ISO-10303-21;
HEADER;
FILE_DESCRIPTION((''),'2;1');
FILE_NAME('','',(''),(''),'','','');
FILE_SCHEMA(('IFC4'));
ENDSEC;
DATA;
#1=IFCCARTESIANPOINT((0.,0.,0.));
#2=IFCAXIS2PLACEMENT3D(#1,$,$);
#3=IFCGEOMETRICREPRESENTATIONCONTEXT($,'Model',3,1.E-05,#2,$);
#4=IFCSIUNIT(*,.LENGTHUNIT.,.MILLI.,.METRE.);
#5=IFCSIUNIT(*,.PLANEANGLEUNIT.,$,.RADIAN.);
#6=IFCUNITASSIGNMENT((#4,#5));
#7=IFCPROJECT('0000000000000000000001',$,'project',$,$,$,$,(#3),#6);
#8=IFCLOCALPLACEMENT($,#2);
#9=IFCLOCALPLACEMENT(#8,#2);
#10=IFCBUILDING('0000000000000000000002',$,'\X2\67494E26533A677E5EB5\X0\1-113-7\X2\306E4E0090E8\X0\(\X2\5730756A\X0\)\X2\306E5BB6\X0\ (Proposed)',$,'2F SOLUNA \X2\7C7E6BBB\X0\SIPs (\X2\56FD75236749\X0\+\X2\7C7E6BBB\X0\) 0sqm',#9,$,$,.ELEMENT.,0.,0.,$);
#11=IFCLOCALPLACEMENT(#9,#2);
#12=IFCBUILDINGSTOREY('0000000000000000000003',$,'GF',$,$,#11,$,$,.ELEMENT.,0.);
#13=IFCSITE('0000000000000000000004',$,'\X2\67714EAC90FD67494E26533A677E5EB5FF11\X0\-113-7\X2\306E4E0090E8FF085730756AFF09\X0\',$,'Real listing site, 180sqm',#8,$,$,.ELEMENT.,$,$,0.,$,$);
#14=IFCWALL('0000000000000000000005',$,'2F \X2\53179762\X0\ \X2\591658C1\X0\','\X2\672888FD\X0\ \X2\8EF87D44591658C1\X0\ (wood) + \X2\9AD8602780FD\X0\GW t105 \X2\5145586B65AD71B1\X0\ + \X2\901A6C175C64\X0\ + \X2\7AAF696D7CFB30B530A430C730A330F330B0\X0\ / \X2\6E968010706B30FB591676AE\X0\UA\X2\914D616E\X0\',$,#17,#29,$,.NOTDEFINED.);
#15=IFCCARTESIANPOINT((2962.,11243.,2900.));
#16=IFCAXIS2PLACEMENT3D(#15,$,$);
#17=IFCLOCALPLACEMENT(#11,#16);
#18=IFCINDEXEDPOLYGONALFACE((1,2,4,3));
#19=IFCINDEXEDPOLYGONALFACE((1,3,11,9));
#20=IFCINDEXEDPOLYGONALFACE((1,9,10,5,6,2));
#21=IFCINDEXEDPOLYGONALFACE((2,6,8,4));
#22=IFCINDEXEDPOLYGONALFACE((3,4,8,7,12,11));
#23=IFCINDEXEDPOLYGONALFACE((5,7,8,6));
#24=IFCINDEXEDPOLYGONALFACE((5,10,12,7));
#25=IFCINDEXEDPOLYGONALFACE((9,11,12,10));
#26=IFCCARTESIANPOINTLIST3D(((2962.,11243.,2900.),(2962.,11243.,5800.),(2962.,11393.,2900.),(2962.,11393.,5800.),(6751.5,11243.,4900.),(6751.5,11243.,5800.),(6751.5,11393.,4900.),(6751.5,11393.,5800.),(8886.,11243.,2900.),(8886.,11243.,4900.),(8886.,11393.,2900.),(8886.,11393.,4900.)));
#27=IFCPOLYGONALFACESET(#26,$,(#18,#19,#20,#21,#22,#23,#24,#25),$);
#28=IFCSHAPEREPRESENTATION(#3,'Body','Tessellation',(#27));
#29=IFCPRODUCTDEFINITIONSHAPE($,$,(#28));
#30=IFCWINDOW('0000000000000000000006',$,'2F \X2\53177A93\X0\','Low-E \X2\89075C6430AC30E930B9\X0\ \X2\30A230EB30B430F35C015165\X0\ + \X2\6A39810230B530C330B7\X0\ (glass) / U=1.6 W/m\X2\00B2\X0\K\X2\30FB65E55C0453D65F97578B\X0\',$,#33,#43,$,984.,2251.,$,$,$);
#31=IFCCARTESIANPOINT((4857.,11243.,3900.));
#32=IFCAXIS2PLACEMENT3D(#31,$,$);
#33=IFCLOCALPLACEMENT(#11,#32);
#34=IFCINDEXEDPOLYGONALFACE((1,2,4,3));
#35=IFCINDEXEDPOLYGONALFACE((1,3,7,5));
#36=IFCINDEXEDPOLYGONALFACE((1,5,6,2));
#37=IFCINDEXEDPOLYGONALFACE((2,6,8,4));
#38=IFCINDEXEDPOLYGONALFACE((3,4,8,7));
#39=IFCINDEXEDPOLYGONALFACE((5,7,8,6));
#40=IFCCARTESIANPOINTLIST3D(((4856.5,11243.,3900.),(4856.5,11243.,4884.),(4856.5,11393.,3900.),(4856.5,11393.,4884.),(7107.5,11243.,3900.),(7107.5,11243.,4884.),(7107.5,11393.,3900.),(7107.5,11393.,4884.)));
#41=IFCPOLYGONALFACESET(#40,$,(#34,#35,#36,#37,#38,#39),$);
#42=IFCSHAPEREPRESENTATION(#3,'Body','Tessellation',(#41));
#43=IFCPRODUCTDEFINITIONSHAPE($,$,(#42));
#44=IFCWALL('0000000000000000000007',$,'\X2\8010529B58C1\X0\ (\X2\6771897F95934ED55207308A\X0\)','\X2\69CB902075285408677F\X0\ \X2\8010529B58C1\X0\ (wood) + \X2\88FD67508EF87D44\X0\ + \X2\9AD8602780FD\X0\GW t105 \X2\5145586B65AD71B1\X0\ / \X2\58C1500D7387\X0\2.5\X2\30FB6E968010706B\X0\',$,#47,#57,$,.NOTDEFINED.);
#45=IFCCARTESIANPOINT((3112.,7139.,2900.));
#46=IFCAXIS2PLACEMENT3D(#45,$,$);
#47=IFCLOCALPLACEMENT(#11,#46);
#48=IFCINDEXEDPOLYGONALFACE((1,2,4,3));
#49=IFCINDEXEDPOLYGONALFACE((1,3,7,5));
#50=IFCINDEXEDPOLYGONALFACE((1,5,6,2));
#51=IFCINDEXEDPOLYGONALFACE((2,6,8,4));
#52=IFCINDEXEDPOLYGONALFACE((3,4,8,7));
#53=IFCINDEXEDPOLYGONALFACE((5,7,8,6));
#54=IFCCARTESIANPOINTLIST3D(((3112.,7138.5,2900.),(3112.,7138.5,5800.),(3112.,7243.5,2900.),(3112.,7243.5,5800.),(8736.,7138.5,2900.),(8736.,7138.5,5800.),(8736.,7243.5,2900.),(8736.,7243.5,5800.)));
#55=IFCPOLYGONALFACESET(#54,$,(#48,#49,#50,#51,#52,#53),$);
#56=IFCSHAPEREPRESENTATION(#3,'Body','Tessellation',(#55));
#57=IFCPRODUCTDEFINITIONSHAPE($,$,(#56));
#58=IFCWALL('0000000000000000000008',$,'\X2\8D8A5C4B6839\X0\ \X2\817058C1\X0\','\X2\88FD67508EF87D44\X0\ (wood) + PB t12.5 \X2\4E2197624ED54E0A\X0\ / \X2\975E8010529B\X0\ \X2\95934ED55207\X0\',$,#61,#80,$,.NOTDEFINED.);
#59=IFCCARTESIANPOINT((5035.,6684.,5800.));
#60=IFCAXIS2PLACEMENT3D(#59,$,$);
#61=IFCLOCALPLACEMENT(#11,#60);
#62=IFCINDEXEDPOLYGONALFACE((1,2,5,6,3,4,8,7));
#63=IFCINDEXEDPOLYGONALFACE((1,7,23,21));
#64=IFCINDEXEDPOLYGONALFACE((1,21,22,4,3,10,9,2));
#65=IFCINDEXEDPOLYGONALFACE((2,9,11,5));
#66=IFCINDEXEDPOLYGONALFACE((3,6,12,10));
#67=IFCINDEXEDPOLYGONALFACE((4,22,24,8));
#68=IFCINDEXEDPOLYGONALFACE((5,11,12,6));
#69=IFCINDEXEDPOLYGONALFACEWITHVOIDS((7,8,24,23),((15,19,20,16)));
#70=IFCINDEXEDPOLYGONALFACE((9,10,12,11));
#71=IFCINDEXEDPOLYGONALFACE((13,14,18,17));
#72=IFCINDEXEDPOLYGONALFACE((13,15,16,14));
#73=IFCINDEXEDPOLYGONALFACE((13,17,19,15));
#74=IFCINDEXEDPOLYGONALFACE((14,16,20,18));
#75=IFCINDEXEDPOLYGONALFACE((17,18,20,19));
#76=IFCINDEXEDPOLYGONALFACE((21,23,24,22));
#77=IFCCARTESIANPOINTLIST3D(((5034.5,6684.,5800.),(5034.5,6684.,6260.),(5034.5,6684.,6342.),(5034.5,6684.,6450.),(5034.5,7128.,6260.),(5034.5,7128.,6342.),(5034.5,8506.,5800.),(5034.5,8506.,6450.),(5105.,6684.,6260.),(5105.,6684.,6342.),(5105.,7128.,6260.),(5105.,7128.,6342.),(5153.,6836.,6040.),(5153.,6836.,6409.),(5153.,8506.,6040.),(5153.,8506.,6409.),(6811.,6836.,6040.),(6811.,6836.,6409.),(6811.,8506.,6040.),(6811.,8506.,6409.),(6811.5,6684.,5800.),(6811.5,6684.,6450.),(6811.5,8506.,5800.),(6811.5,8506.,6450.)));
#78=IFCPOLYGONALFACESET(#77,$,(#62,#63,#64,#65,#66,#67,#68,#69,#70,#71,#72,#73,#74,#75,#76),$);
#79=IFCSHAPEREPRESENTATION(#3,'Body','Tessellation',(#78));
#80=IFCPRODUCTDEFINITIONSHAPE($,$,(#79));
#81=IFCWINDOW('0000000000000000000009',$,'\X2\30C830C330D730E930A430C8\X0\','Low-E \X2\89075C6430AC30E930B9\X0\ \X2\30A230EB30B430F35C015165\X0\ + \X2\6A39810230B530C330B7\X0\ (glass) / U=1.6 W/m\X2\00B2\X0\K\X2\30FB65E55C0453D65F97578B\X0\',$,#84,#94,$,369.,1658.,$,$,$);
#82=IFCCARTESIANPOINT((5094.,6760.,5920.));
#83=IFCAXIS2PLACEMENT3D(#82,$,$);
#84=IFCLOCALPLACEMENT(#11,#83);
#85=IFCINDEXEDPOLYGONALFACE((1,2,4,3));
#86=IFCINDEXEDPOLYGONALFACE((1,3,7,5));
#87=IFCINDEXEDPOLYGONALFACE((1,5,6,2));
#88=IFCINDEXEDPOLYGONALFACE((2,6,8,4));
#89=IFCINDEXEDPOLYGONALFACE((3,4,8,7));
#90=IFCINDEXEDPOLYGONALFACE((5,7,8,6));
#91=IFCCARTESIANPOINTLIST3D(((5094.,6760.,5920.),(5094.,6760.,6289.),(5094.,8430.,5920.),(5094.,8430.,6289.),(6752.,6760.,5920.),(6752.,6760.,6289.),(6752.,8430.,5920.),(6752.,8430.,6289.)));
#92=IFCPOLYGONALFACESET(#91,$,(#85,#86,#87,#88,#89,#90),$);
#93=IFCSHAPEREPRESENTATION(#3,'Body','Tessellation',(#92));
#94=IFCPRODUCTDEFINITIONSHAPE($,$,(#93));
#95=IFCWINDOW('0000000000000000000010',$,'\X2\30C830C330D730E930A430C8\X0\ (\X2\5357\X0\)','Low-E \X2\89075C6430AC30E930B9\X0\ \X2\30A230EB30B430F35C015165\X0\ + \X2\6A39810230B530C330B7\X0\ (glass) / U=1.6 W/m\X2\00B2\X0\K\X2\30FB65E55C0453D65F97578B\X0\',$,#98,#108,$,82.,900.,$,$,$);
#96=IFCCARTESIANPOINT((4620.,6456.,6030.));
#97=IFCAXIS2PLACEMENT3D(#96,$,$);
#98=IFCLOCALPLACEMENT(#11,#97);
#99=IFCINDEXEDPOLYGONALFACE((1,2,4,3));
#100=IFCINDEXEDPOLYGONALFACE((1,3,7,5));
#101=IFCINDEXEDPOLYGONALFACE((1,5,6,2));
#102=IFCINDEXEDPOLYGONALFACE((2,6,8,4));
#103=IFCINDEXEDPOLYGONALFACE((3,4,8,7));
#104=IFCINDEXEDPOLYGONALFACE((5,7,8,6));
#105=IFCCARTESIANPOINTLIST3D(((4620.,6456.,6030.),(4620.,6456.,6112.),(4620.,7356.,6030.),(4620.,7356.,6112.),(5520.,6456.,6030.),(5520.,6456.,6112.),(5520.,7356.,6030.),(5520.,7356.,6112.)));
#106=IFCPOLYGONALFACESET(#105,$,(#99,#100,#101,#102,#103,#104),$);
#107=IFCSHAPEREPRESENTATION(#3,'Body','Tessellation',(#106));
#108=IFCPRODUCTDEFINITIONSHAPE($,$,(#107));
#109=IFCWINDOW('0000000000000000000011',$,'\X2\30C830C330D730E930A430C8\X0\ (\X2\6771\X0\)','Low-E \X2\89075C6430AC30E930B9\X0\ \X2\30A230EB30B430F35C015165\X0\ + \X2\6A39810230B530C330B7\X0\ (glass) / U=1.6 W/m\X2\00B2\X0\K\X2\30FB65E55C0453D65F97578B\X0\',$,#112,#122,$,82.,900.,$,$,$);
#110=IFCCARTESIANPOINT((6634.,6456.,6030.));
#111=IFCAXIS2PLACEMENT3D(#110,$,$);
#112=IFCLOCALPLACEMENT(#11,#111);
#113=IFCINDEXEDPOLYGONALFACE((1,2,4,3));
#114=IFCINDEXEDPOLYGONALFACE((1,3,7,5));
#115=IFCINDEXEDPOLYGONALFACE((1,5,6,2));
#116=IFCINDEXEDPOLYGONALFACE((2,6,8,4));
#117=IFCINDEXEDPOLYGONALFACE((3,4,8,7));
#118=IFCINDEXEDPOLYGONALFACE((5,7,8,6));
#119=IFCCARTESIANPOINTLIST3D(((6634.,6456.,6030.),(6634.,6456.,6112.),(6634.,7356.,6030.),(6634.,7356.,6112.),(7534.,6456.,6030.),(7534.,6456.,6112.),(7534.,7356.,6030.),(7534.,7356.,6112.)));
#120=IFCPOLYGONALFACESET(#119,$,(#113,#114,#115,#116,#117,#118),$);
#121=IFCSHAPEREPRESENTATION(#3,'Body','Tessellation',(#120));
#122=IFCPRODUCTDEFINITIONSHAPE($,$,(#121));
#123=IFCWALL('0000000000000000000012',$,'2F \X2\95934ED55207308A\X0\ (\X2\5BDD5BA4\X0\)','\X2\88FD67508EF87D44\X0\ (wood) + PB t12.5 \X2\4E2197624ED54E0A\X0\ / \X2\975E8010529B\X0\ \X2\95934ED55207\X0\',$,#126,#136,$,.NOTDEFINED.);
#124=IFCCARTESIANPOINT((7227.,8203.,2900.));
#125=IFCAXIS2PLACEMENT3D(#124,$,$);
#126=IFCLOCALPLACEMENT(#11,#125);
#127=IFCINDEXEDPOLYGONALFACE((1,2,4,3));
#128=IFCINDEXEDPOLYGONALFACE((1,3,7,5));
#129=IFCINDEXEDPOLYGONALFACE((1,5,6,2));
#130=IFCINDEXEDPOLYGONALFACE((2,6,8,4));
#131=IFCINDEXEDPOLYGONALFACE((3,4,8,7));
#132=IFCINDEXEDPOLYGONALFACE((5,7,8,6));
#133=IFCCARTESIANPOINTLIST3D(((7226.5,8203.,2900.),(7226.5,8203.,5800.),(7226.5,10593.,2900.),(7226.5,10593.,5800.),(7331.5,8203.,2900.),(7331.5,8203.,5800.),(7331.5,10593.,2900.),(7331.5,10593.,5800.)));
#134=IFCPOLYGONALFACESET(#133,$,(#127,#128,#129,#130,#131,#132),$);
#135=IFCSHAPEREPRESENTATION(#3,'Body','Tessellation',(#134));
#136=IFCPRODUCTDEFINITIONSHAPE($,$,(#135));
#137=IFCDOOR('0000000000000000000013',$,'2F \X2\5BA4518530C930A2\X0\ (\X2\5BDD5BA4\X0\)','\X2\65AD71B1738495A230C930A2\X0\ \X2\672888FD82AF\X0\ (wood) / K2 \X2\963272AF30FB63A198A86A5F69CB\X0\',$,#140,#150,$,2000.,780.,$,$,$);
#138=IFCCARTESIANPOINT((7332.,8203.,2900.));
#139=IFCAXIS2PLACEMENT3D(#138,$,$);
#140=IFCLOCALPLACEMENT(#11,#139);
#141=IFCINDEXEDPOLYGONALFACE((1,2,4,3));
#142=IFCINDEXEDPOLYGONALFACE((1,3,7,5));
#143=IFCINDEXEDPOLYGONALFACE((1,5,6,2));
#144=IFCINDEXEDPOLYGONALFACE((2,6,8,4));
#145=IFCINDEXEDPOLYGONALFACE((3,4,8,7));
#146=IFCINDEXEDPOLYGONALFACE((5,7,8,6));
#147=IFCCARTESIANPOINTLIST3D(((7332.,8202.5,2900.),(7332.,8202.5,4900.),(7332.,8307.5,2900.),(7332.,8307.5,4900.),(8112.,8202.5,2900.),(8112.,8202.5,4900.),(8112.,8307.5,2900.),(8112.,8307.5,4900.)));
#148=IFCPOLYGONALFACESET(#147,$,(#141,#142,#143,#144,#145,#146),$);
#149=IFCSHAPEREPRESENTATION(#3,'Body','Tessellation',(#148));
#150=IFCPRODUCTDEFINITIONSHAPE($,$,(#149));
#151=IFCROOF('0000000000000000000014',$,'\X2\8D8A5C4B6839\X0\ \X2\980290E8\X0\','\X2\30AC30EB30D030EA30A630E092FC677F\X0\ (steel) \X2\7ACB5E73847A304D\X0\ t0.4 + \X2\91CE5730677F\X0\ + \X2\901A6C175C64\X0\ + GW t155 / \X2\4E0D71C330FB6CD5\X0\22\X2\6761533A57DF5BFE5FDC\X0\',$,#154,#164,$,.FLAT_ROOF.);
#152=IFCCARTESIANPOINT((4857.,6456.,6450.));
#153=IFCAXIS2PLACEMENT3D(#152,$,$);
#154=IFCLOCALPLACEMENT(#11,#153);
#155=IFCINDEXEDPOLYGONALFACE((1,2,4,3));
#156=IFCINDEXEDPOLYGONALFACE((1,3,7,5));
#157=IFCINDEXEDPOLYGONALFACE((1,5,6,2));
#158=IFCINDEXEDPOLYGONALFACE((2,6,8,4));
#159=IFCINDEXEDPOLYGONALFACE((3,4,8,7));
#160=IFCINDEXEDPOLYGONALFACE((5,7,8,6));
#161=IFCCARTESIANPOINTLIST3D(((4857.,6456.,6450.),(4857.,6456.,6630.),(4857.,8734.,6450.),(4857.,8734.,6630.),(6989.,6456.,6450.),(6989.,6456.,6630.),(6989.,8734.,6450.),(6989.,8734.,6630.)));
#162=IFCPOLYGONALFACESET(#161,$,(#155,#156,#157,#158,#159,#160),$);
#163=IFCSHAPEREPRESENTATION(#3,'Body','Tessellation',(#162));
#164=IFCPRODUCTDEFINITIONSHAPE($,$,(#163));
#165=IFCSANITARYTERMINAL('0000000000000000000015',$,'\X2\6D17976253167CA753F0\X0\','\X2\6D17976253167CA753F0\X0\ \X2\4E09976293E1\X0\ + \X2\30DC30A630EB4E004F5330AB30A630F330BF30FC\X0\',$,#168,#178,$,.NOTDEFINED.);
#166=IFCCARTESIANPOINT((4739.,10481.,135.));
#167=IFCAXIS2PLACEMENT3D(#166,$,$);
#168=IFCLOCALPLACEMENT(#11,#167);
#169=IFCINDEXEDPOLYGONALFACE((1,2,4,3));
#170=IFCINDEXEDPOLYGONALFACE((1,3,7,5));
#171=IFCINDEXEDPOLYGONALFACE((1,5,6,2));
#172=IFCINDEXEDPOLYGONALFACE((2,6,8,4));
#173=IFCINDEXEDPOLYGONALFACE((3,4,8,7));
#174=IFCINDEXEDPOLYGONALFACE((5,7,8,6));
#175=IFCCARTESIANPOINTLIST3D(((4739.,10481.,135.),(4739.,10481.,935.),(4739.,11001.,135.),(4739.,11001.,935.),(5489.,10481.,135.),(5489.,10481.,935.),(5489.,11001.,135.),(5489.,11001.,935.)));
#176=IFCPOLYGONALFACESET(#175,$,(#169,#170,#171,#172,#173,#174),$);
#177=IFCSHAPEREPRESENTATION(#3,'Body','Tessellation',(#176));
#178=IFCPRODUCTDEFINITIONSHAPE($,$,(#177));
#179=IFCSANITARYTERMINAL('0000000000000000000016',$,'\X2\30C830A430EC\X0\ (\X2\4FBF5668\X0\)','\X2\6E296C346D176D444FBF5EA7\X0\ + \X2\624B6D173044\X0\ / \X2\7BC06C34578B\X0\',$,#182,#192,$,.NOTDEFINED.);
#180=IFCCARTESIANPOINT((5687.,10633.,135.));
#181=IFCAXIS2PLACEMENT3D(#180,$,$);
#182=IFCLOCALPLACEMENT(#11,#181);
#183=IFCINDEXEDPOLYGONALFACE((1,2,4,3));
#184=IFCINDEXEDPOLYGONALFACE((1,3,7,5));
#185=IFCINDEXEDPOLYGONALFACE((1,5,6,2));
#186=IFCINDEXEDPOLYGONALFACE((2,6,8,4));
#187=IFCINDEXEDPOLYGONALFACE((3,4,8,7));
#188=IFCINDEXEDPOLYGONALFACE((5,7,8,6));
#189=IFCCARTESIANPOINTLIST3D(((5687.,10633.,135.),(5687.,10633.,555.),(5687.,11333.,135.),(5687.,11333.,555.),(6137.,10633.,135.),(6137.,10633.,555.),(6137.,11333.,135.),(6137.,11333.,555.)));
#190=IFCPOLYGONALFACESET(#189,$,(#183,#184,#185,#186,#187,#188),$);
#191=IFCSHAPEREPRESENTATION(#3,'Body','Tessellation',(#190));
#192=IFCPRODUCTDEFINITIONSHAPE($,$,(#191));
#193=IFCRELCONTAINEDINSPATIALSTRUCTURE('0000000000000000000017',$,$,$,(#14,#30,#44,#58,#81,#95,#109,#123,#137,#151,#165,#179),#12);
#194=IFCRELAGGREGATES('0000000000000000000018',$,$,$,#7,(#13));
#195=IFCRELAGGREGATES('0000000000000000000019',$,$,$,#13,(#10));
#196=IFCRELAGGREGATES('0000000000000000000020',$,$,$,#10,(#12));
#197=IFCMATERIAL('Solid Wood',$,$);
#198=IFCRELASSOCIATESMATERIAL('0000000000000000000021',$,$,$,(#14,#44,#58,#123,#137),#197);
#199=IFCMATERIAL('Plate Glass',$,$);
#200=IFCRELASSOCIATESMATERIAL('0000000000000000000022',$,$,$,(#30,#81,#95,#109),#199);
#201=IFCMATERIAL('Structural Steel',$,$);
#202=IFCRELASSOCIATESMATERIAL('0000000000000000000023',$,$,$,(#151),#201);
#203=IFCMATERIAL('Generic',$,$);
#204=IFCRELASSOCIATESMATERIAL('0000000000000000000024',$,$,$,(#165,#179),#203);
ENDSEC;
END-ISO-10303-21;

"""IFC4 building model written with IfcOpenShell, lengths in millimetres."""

from ifc_helpers import new_model, si_unit, frame, frame_2d, origin, place, context, project, spatial, rectangle, extrude, material, element, fill, save


model = new_model("IFC4")

# Units and contexts
model_context = context("Model", 3, precision=1e-05, world=origin())
ifc_project = project(units=[si_unit("LENGTHUNIT", "METRE", prefix="MILLI"), si_unit("PLANEANGLEUNIT", "RADIAN")], contexts=[model_context])

# Site, building, storey
site_placement = place(None, origin())
site = spatial("IfcSite", under=ifc_project, at=site_placement, Name="東京都杉並区松庵１-113-7の一部（地番）", ObjectType="Real listing site, 180sqm", CompositionType="ELEMENT", RefElevation=0.0)
building_placement = place(site_placement, origin())
building = spatial("IfcBuilding", under=site, at=building_placement, Name="杉並区松庵1-113-7の一部(地番)の家 (Proposed)", ObjectType="2F SOLUNA 籾殻SIPs (国産杉+籾殻) 0sqm", CompositionType="ELEMENT", ElevationOfRefHeight=0.0, ElevationOfTerrain=0.0)
storey_placement = place(building_placement, origin())
storey = spatial("IfcBuildingStorey", under=building, at=storey_placement, Name="GF", CompositionType="ELEMENT", Elevation=0.0)

# Wall, opening, window
ifc_material_1 = material(Name="Solid Wood")
wall_1_placement = place(storey_placement, frame((2962.0, 11243.0, 2900.0)))
wall_1 = element("IfcWall", 1, at=wall_1_placement, inside=storey, material=ifc_material_1, Name="2F 北面 外壁", Description="木製 軸組外壁 (wood) + 高性能GW t105 充填断熱 + 通気層 + 窯業系サイディング / 準耐火・外皮UA配慮", PredefinedType="NOTDEFINED", context=model_context, shape_type="SweptSolid", body=[
    extrude(rectangle(XDim=5924.0, YDim=150.0, at=frame_2d((2962.0, 75.0))), frame((2962.0, 11243.0, 2900.0)), (0.0, 0.0, 1.0), 2900.0),
])
opening_1_placement = place(storey_placement, frame((4857.0, 11243.0, 3900.0)))
opening_1 = element("IfcOpeningElement", 2, at=opening_1_placement, cuts=wall_1, PredefinedType="NOTDEFINED", context=model_context, shape_type="SweptSolid", body=[
    extrude(rectangle(XDim=2251.0, YDim=150.0, at=frame_2d((1125.0, 75.0))), frame((4857.0, 11243.0, 3900.0)), (0.0, 0.0, 1.0), 984.0),
])
ifc_material_2 = material(Name="Plate Glass")
window_1_placement = place(storey_placement, frame((4857.0, 11243.0, 3900.0)))
window_1 = element("IfcWindow", 3, at=window_1_placement, inside=storey, material=ifc_material_2, Name="2F 北窓", Description="Low-E 複層ガラス アルゴン封入 + 樹脂サッシ (glass) / U=1.6 W/m²K・日射取得型", OverallHeight=984.0, OverallWidth=2251.0, context=model_context, shape_type="SweptSolid", body=[
    extrude(rectangle(XDim=2251.0, YDim=150.0, at=frame_2d((1125.0, 75.0))), frame((4857.0, 11243.0, 3900.0)), (0.0, 0.0, 1.0), 984.0),
])
fill(opening_1, window_1)

# Wall
wall_2_placement = place(storey_placement, frame((3112.0, 7139.0, 2900.0)))
element("IfcWall", 4, at=wall_2_placement, inside=storey, material=ifc_material_1, Name="耐力壁 (東西間仕切り)", Description="構造用合板 耐力壁 (wood) + 製材軸組 + 高性能GW t105 充填断熱 / 壁倍率2.5・準耐火", PredefinedType="NOTDEFINED", context=model_context, shape_type="SweptSolid", body=[
    extrude(rectangle(XDim=5624.0, YDim=105.0, at=frame_2d((2812.0, 52.0))), frame((3112.0, 7139.0, 2900.0)), (0.0, 0.0, 1.0), 2900.0),
])

# Wall, openings, windows
wall_3_placement = place(storey_placement, frame((5035.0, 6684.0, 5800.0)))
wall_3 = element("IfcWall", 5, at=wall_3_placement, inside=storey, material=ifc_material_1, Name="越屋根 腰壁", Description="製材軸組 (wood) + PB t12.5 両面仕上 / 非耐力 間仕切", PredefinedType="NOTDEFINED", context=model_context, shape_type="SweptSolid", body=[
    extrude(rectangle(XDim=1777.0, YDim=1822.0, at=frame_2d((888.0, 911.0))), frame((5035.0, 6684.0, 5800.0)), (0.0, 0.0, 1.0), 650.0),
])
opening_2_placement = place(storey_placement, frame((5094.0, 6760.0, 5920.0)))
opening_2 = element("IfcOpeningElement", 6, at=opening_2_placement, cuts=wall_3, PredefinedType="NOTDEFINED", context=model_context, shape_type="SweptSolid", body=[
    extrude(rectangle(XDim=1658.0, YDim=1670.0, at=frame_2d((829.0, 835.0))), frame((5094.0, 6760.0, 5920.0)), (0.0, 0.0, 1.0), 369.0),
])
opening_3_placement = place(storey_placement, frame((4620.0, 6456.0, 6030.0)))
opening_3 = element("IfcOpeningElement", 7, at=opening_3_placement, cuts=wall_3, PredefinedType="NOTDEFINED", context=model_context, shape_type="SweptSolid", body=[
    extrude(rectangle(XDim=900.0, YDim=900.0, at=frame_2d((450.0, 450.0))), frame((4620.0, 6456.0, 6030.0)), (0.0, 0.0, 1.0), 82.0),
])
opening_4_placement = place(storey_placement, frame((6634.0, 6456.0, 6030.0)))
opening_4 = element("IfcOpeningElement", 8, at=opening_4_placement, cuts=wall_3, PredefinedType="NOTDEFINED", context=model_context, shape_type="SweptSolid", body=[
    extrude(rectangle(XDim=900.0, YDim=900.0, at=frame_2d((450.0, 450.0))), frame((6634.0, 6456.0, 6030.0)), (0.0, 0.0, 1.0), 82.0),
])
window_2_placement = place(storey_placement, frame((5094.0, 6760.0, 5920.0)))
window_2 = element("IfcWindow", 9, at=window_2_placement, inside=storey, material=ifc_material_2, Name="トップライト", Description="Low-E 複層ガラス アルゴン封入 + 樹脂サッシ (glass) / U=1.6 W/m²K・日射取得型", OverallHeight=369.0, OverallWidth=1658.0, context=model_context, shape_type="SweptSolid", body=[
    extrude(rectangle(XDim=1658.0, YDim=1670.0, at=frame_2d((829.0, 835.0))), frame((5094.0, 6760.0, 5920.0)), (0.0, 0.0, 1.0), 369.0),
])
fill(opening_2, window_2)
window_3_placement = place(storey_placement, frame((4620.0, 6456.0, 6030.0)))
window_3 = element("IfcWindow", 10, at=window_3_placement, inside=storey, material=ifc_material_2, Name="トップライト (南)", Description="Low-E 複層ガラス アルゴン封入 + 樹脂サッシ (glass) / U=1.6 W/m²K・日射取得型", OverallHeight=82.0, OverallWidth=900.0, context=model_context, shape_type="SweptSolid", body=[
    extrude(rectangle(XDim=900.0, YDim=900.0, at=frame_2d((450.0, 450.0))), frame((4620.0, 6456.0, 6030.0)), (0.0, 0.0, 1.0), 82.0),
])
fill(opening_3, window_3)
window_4_placement = place(storey_placement, frame((6634.0, 6456.0, 6030.0)))
window_4 = element("IfcWindow", 11, at=window_4_placement, inside=storey, material=ifc_material_2, Name="トップライト (東)", Description="Low-E 複層ガラス アルゴン封入 + 樹脂サッシ (glass) / U=1.6 W/m²K・日射取得型", OverallHeight=82.0, OverallWidth=900.0, context=model_context, shape_type="SweptSolid", body=[
    extrude(rectangle(XDim=900.0, YDim=900.0, at=frame_2d((450.0, 450.0))), frame((6634.0, 6456.0, 6030.0)), (0.0, 0.0, 1.0), 82.0),
])
fill(opening_4, window_4)

# Wall
wall_4_placement = place(storey_placement, frame((7227.0, 8203.0, 2900.0)))
element("IfcWall", 12, at=wall_4_placement, inside=storey, material=ifc_material_1, Name="2F 間仕切り (寝室)", Description="製材軸組 (wood) + PB t12.5 両面仕上 / 非耐力 間仕切", PredefinedType="NOTDEFINED", context=model_context, shape_type="SweptSolid", body=[
    extrude(rectangle(XDim=105.0, YDim=2390.0, at=frame_2d((52.0, 1195.0))), frame((7227.0, 8203.0, 2900.0)), (0.0, 0.0, 1.0), 2900.0),
])

# Door
door_placement = place(storey_placement, frame((7332.0, 8203.0, 2900.0)))
element("IfcDoor", 13, at=door_placement, inside=storey, material=ifc_material_1, Name="2F 室内ドア (寝室)", Description="断熱玄関ドア 木製芯 (wood) / K2 防犯・採風機構", OverallHeight=2000.0, OverallWidth=780.0, context=model_context, shape_type="SweptSolid", body=[
    extrude(rectangle(XDim=780.0, YDim=105.0, at=frame_2d((390.0, 52.0))), frame((7332.0, 8203.0, 2900.0)), (0.0, 0.0, 1.0), 2000.0),
])

# Roof
ifc_material_3 = material(Name="Structural Steel")
roof_placement = place(storey_placement, frame((4857.0, 6456.0, 6450.0)))
element("IfcRoof", 14, at=roof_placement, inside=storey, material=ifc_material_3, Name="越屋根 頂部", Description="ガルバリウム鋼板 (steel) 立平葺き t0.4 + 野地板 + 通気層 + GW t155 / 不燃・法22条区域対応", PredefinedType="FLAT_ROOF", context=model_context, shape_type="SweptSolid", body=[
    extrude(rectangle(XDim=2132.0, YDim=2278.0, at=frame_2d((1066.0, 1139.0))), frame((4857.0, 6456.0, 6450.0)), (0.0, 0.0, 1.0), 180.0),
])

# Sanitary terminals
ifc_material_4 = material(Name="Generic")
sanitary_terminal_1_placement = place(storey_placement, frame((4739.0, 10481.0, 135.0)))
element("IfcSanitaryTerminal", 15, at=sanitary_terminal_1_placement, inside=storey, material=ifc_material_4, Name="洗面化粧台", Description="洗面化粧台 三面鏡 + ボウル一体カウンター", PredefinedType="NOTDEFINED", context=model_context, shape_type="SweptSolid", body=[
    extrude(rectangle(XDim=750.0, YDim=520.0, at=frame_2d((375.0, 260.0))), frame((4739.0, 10481.0, 135.0)), (0.0, 0.0, 1.0), 800.0),
])
sanitary_terminal_2_placement = place(storey_placement, frame((5687.0, 10633.0, 135.0)))
element("IfcSanitaryTerminal", 16, at=sanitary_terminal_2_placement, inside=storey, material=ifc_material_4, Name="トイレ (便器)", Description="温水洗浄便座 + 手洗い / 節水型", PredefinedType="NOTDEFINED", context=model_context, shape_type="SweptSolid", body=[
    extrude(rectangle(XDim=450.0, YDim=700.0, at=frame_2d((225.0, 350.0))), frame((5687.0, 10633.0, 135.0)), (0.0, 0.0, 1.0), 420.0),
])

save(model, "model.ifc")
